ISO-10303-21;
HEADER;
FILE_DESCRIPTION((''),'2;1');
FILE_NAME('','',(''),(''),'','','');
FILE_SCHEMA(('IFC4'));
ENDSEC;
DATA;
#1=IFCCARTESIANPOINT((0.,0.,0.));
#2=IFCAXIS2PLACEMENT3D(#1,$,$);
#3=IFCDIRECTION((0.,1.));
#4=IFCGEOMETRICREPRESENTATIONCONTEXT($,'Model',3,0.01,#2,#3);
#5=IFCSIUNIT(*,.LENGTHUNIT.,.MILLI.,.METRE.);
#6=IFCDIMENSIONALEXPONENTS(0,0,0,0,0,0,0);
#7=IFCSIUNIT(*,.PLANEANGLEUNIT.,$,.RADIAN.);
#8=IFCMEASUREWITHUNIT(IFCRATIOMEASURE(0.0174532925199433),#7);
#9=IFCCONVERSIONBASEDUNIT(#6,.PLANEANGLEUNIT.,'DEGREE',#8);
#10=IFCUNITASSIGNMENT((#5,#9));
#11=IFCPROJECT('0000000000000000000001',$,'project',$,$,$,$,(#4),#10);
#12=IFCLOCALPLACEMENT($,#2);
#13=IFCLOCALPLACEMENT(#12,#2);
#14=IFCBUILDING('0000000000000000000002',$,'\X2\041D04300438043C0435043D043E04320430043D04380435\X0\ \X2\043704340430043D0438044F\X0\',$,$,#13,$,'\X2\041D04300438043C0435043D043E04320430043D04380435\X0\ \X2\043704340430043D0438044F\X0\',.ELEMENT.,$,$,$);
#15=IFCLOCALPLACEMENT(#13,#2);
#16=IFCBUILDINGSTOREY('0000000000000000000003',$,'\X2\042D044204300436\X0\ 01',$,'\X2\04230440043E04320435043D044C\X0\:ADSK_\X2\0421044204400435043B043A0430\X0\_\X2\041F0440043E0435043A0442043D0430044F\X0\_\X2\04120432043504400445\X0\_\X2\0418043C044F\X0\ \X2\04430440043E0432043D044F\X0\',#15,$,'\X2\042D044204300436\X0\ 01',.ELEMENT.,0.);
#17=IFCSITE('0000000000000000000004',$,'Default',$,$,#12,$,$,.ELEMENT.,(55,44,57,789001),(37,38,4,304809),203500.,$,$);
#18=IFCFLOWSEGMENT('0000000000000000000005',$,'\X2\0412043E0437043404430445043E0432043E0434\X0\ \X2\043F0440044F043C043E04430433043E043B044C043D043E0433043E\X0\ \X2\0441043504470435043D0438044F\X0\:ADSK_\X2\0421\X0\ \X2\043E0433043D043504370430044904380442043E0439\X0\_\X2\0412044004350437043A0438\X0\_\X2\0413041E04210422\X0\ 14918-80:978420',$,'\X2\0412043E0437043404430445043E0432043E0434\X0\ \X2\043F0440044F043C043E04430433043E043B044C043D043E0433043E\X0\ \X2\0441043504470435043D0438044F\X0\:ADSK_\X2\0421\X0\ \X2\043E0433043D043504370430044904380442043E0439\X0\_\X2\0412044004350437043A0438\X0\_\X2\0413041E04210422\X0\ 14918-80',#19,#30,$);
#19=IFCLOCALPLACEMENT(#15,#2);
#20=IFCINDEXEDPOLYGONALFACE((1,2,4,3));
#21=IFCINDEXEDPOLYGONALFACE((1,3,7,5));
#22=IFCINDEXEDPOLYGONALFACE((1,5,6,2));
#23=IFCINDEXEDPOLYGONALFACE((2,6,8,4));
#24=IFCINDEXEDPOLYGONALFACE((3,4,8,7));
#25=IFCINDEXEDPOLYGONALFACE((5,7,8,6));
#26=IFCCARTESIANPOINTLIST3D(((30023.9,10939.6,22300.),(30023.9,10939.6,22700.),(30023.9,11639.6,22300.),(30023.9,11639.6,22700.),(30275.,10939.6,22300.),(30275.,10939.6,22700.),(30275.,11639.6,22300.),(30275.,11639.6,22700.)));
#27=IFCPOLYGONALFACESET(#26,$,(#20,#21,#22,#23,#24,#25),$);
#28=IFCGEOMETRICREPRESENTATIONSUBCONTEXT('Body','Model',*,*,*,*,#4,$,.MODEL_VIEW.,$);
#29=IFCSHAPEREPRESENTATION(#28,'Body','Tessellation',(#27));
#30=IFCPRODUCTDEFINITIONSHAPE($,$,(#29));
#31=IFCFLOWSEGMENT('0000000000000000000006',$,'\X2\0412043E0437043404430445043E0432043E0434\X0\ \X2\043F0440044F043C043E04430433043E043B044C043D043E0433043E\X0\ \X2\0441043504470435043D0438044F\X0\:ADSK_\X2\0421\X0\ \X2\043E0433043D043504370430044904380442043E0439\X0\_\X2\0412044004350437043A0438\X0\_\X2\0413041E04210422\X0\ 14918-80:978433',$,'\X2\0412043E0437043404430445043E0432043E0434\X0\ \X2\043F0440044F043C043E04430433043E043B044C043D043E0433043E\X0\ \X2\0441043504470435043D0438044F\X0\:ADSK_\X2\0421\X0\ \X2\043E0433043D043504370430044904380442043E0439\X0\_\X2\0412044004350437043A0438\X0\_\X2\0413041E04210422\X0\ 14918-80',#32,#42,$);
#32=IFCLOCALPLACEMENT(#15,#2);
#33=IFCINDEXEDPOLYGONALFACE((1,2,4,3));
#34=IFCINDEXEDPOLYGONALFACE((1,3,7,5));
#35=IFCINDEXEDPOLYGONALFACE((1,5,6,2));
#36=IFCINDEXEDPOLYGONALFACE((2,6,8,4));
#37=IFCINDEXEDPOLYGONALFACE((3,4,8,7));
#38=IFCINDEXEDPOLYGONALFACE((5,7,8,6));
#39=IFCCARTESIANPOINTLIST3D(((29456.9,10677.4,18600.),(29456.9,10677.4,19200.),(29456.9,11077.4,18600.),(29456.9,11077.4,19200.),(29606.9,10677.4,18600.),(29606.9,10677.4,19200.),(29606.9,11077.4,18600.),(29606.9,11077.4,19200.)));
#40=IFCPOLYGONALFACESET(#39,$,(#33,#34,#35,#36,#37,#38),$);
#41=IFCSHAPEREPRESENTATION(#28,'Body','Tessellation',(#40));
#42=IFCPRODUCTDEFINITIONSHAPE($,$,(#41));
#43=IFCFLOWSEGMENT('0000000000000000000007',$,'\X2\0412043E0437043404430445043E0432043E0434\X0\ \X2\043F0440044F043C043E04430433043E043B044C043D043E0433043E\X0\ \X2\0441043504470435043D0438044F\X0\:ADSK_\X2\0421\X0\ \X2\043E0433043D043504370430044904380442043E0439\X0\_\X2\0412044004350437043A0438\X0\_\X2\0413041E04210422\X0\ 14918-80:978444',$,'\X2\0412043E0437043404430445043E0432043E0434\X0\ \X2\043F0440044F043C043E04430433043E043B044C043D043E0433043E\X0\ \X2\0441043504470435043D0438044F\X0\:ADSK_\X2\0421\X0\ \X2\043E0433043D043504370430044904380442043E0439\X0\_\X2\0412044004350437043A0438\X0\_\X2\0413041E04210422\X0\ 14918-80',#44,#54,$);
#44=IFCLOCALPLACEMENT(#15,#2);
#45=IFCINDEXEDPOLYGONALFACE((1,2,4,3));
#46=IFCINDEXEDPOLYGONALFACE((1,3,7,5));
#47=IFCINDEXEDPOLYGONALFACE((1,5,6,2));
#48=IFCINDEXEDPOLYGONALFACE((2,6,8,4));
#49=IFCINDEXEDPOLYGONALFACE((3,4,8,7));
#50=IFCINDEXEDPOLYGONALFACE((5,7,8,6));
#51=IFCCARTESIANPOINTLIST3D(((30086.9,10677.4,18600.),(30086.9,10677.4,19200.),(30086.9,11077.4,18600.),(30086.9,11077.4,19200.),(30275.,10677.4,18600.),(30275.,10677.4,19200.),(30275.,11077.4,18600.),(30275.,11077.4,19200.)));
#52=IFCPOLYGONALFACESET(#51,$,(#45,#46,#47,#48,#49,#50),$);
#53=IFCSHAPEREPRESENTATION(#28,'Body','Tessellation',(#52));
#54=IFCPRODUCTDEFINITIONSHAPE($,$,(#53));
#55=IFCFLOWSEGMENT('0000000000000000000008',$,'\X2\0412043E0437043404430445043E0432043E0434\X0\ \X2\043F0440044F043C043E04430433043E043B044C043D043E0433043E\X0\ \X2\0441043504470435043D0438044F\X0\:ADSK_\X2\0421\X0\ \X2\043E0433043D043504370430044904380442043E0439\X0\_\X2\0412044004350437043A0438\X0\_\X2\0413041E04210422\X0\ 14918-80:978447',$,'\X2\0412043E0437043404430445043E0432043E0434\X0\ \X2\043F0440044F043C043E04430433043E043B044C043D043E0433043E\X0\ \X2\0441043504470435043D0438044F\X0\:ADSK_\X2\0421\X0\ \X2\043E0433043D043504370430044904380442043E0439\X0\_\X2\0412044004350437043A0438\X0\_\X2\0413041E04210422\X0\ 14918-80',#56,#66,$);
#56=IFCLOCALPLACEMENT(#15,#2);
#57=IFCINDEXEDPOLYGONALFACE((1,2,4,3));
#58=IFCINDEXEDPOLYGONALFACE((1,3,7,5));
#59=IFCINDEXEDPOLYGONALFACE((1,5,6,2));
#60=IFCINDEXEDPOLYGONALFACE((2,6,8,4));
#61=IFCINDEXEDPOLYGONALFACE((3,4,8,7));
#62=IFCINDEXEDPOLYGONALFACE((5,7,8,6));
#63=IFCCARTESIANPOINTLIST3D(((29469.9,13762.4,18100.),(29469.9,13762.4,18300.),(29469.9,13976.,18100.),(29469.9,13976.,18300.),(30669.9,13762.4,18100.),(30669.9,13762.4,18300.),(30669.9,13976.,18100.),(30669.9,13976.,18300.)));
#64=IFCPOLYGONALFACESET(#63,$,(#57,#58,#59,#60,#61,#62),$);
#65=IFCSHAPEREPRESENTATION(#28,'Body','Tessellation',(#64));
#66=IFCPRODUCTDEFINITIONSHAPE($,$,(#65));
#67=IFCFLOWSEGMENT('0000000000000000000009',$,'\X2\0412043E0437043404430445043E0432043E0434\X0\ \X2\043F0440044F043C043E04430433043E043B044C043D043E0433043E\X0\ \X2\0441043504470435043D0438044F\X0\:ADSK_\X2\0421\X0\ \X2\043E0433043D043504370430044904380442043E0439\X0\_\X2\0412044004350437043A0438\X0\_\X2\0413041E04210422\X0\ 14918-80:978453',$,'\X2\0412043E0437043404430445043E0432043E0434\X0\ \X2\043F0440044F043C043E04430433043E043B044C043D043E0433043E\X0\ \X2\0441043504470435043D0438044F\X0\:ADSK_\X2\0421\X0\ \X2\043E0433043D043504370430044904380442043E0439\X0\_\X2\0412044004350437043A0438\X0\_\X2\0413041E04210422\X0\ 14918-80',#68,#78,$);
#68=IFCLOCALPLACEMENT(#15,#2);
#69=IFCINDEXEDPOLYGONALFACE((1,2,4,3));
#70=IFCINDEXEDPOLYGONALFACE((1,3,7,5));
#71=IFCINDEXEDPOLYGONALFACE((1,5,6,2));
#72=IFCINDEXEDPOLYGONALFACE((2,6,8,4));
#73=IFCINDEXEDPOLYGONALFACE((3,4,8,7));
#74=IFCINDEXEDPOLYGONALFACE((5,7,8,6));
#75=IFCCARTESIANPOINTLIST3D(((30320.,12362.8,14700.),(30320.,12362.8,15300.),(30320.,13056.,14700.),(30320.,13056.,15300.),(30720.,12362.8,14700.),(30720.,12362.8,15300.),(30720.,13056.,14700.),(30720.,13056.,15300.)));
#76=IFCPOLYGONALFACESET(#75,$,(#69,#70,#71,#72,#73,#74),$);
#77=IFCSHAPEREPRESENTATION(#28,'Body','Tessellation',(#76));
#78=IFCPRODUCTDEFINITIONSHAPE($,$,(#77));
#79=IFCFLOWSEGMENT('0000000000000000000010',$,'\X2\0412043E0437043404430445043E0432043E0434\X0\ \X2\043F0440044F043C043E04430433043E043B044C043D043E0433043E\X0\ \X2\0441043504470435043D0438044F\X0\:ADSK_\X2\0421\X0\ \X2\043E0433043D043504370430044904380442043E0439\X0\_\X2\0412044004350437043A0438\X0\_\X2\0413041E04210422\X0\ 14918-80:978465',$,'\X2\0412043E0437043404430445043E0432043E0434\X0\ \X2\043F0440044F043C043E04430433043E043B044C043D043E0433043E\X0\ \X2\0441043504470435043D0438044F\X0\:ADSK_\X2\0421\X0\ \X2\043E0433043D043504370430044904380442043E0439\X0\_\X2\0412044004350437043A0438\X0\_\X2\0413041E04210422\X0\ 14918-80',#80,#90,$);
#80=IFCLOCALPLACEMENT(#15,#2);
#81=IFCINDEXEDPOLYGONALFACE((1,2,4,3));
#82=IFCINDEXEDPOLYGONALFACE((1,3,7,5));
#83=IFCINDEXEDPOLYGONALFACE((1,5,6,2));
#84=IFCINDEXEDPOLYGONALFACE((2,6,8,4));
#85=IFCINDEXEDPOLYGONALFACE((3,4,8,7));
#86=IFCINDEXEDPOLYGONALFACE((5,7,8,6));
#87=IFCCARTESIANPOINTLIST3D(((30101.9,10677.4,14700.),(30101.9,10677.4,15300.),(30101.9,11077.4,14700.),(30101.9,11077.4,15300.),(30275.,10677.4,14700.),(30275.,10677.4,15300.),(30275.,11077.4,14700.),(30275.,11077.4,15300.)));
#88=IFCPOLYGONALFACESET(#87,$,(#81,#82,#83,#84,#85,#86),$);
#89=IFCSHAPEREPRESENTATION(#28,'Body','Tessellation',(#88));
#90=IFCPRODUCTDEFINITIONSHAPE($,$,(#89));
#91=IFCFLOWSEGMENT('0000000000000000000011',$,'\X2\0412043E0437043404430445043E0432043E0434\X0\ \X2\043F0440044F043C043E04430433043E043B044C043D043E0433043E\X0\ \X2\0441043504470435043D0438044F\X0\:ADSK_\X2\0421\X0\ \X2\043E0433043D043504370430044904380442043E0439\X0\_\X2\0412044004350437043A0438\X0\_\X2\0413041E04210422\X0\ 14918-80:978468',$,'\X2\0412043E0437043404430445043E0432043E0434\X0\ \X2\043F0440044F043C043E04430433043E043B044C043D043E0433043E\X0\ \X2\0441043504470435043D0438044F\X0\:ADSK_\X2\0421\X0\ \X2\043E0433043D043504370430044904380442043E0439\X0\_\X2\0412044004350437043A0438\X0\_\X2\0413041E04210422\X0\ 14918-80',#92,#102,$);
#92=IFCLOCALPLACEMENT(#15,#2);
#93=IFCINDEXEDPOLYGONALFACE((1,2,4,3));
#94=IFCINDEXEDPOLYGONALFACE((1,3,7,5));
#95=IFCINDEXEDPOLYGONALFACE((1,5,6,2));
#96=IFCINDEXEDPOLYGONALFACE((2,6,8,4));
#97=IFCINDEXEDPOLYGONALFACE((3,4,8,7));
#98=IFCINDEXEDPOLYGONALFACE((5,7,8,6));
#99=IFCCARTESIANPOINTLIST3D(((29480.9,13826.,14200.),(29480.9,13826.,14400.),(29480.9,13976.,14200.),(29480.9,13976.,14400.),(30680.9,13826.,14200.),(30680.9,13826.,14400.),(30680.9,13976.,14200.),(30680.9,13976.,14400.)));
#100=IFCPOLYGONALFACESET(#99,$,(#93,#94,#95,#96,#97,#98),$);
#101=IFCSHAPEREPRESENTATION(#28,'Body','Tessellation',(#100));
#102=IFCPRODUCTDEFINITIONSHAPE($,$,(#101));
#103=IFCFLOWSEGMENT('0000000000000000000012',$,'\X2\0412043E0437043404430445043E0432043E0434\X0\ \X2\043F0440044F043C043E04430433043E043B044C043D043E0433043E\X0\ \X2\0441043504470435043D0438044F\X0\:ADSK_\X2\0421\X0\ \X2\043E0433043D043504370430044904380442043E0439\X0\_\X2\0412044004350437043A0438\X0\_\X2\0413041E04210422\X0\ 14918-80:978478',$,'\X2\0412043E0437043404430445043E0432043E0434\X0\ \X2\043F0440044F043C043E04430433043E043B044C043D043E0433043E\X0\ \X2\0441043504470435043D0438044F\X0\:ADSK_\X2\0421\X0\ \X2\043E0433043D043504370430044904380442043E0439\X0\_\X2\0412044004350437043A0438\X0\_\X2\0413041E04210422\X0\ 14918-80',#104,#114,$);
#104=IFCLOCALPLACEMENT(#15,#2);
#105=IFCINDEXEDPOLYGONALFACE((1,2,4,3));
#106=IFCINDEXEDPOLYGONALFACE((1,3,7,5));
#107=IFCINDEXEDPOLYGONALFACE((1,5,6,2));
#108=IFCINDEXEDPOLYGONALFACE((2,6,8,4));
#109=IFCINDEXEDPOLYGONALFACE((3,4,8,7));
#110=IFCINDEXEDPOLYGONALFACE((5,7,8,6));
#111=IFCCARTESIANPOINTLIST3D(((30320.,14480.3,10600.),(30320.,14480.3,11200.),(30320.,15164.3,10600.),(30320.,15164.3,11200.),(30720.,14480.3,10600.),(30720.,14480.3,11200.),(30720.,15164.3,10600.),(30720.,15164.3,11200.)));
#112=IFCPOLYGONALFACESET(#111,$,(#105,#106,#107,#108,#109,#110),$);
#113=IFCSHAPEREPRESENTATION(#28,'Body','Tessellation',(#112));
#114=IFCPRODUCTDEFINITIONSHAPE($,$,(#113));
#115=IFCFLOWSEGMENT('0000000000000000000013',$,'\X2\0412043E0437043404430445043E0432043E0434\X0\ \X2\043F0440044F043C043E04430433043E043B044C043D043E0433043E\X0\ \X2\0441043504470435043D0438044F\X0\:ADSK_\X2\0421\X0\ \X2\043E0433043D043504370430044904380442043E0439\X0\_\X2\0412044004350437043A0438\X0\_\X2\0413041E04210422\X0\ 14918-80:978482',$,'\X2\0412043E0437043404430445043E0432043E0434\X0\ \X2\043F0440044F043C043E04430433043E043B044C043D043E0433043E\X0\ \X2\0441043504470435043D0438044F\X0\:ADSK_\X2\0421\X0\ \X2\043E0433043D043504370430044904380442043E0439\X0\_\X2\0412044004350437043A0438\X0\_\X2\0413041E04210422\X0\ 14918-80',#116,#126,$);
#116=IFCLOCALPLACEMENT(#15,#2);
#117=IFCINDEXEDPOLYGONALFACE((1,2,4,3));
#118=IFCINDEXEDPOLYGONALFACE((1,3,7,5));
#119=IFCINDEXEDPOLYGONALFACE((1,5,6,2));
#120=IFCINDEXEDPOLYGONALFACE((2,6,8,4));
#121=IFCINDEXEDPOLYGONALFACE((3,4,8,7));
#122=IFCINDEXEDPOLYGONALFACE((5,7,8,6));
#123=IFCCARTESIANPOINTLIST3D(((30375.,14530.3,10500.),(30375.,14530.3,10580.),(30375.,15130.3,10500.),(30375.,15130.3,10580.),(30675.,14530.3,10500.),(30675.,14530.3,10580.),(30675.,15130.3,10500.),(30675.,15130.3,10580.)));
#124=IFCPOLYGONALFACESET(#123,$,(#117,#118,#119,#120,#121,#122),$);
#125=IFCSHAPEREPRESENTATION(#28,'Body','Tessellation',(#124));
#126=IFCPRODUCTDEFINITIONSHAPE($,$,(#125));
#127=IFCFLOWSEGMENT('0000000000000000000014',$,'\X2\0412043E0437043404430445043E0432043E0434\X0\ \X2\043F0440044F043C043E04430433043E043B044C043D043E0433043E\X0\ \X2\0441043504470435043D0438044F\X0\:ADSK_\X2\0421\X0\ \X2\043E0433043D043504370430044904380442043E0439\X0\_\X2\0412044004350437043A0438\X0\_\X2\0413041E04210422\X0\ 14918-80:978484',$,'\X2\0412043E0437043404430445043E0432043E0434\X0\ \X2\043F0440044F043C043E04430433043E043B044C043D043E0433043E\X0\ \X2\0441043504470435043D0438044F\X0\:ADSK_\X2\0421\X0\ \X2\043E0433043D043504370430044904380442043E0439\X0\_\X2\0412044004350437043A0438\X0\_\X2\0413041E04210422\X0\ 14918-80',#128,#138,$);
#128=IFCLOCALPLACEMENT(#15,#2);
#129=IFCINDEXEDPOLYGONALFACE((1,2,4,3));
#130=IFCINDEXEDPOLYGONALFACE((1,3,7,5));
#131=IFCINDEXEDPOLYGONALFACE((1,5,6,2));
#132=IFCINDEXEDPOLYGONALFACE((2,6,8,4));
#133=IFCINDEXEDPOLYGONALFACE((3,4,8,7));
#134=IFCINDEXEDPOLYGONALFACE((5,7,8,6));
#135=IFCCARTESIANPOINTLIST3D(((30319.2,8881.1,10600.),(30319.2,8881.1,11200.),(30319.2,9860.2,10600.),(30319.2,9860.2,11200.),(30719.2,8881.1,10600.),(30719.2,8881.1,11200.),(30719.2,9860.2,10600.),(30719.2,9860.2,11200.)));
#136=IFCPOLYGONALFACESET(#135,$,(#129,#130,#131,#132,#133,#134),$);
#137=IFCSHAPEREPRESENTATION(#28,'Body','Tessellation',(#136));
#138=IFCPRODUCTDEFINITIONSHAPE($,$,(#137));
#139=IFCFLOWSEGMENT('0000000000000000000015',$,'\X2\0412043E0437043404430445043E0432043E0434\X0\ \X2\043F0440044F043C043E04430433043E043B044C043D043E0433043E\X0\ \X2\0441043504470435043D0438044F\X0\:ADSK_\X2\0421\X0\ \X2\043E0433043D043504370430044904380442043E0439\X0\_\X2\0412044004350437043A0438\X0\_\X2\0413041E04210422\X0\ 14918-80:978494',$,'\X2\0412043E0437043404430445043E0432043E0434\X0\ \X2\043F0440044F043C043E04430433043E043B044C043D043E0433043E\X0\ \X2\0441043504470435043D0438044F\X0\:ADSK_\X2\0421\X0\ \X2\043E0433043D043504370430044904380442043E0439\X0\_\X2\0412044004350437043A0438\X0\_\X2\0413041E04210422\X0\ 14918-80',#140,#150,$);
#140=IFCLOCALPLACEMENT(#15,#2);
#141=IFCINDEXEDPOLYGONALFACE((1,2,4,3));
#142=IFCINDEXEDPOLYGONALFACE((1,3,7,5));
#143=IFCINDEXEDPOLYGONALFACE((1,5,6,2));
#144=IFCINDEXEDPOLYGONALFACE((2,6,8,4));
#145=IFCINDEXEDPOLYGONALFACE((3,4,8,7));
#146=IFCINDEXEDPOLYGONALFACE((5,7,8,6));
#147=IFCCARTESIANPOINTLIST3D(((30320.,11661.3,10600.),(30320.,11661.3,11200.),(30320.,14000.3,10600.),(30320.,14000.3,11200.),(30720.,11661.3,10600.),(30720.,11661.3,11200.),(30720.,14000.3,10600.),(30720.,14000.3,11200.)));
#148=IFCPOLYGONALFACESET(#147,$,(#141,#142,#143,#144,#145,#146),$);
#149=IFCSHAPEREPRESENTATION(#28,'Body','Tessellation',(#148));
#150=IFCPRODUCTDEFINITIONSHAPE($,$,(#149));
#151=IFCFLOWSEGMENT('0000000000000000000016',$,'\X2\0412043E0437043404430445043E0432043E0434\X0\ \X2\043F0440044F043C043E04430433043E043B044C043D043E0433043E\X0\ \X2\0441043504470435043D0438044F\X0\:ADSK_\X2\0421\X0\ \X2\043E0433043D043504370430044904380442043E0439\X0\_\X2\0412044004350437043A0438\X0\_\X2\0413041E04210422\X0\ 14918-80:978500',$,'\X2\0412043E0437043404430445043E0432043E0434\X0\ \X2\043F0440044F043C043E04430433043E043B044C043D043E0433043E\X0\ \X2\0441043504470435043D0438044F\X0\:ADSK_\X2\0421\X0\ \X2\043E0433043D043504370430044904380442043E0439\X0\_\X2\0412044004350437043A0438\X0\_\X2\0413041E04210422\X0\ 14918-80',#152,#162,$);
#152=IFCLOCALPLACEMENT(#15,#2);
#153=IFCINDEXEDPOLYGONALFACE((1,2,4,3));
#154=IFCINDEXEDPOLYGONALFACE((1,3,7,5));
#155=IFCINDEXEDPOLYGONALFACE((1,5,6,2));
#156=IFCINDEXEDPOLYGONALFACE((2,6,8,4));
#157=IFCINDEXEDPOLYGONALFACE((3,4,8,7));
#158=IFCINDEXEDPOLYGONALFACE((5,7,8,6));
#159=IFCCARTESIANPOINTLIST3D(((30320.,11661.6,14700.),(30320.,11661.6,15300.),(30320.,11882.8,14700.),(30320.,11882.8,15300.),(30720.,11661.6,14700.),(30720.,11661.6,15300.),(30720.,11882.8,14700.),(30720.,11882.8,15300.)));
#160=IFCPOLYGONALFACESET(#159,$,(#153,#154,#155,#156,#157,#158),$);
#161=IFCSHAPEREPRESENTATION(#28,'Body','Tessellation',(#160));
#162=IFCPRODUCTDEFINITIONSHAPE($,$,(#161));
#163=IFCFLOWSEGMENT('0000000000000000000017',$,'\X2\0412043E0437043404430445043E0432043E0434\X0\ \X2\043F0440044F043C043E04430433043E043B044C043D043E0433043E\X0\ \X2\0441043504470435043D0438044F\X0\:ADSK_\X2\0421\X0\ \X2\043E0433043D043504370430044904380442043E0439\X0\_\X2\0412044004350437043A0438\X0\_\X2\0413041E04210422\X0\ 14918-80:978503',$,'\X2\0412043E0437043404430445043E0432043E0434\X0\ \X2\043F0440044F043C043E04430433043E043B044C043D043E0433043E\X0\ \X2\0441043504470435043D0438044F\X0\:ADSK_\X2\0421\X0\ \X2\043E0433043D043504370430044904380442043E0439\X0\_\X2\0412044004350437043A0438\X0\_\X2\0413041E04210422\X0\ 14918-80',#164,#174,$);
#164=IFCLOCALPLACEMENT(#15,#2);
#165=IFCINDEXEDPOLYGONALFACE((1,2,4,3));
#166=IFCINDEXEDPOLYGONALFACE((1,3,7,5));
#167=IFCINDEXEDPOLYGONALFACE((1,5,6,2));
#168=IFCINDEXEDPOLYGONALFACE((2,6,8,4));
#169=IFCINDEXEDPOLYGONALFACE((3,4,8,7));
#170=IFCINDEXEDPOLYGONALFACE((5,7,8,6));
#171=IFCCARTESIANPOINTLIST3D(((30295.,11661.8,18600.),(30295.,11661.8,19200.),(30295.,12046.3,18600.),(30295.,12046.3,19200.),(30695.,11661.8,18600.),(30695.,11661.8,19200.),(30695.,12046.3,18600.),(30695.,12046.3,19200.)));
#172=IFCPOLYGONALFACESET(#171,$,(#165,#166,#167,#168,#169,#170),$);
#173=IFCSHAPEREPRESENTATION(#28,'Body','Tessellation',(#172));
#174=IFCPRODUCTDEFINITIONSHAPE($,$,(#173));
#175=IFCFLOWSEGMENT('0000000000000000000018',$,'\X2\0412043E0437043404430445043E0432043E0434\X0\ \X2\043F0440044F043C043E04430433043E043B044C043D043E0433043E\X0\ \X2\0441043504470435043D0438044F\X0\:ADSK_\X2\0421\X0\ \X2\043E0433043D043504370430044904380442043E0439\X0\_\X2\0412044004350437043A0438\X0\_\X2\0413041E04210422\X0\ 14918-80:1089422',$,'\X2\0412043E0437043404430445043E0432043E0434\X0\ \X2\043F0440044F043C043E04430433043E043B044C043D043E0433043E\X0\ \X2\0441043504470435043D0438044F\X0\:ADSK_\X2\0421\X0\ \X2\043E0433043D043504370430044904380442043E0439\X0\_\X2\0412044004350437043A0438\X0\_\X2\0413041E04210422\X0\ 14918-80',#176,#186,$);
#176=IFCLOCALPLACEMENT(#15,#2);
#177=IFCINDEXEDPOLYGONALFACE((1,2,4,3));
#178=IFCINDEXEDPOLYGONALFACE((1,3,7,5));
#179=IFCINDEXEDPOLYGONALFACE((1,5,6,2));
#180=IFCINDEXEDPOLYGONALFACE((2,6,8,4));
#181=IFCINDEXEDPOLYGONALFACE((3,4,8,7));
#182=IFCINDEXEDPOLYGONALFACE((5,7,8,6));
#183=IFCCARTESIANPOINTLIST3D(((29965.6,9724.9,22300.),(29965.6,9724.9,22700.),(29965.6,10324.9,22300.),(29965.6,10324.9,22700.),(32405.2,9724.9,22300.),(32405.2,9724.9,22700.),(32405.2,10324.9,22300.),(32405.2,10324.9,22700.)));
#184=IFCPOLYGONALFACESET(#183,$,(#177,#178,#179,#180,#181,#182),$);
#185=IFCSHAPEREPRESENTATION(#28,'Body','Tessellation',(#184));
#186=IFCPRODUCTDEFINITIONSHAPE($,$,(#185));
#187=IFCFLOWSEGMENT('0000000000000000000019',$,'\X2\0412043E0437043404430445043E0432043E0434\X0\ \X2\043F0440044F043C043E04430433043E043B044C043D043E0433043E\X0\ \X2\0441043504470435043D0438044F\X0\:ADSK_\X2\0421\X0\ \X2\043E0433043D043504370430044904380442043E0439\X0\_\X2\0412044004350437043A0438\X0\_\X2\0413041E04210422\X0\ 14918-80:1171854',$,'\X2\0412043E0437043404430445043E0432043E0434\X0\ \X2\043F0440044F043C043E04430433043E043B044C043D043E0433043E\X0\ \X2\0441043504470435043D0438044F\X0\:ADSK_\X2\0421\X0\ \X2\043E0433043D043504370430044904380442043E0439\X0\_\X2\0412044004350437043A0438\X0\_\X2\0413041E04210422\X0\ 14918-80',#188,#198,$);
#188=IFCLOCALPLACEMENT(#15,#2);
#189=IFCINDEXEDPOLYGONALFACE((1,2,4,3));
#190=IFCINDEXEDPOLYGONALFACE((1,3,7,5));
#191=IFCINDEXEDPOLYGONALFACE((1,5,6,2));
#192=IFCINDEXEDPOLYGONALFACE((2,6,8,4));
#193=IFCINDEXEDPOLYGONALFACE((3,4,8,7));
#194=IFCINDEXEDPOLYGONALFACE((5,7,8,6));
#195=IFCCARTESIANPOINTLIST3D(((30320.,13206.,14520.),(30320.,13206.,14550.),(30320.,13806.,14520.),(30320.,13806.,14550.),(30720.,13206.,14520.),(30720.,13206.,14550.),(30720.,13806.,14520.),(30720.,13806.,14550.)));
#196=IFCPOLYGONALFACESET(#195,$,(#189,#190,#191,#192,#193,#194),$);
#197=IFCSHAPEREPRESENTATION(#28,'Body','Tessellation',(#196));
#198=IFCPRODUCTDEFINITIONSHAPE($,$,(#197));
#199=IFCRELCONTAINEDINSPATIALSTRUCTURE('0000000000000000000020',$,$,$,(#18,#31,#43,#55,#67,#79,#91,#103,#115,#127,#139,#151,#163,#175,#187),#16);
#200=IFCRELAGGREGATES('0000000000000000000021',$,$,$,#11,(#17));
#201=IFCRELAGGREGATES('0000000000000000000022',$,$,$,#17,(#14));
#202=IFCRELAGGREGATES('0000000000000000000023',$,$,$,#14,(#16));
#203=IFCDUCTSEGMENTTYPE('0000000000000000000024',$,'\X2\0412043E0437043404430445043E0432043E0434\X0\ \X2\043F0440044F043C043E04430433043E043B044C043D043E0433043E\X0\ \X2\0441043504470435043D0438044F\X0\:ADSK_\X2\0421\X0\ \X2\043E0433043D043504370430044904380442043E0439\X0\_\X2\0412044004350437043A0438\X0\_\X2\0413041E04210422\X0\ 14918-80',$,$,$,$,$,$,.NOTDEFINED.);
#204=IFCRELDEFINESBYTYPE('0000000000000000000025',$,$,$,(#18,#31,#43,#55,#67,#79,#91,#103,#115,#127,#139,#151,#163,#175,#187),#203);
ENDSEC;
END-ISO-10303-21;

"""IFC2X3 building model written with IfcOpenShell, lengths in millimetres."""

from ifc_helpers import new_model, entity, si_unit, converted_unit, direction, frame, origin, origin_2d_with_axis, place, context, subcontext, project, spatial, rectangle, extrude, type_object, element, save


model = new_model("IFC2X3")

# Units and contexts
model_context = context("Model", 3, precision=0.01, world=origin(), true_north=direction((0.0, 1.0)))
body_context = subcontext(model_context, "Body", "Model", "MODEL_VIEW")
ifc_project = project(units=[si_unit("LENGTHUNIT", "METRE", prefix="MILLI"), converted_unit("PLANEANGLEUNIT", "DEGREE", entity("IfcRatioMeasure", 0.0174532925199433), si_unit("PLANEANGLEUNIT", "RADIAN"), dimensions=[0, 0, 0, 0, 0, 0, 0])], contexts=[model_context])

# Site, building, storey
site_placement = place(None, origin())
site = spatial("IfcSite", under=ifc_project, at=site_placement, Name="Default", CompositionType="ELEMENT", RefLatitude=(55, 44, 57, 789001), RefLongitude=(37, 38, 4, 304809), RefElevation=203500.0)
building_placement = place(site_placement, origin())
building = spatial("IfcBuilding", under=site, at=building_placement, Name="Наименование здания", LongName="Наименование здания", CompositionType="ELEMENT")
storey_placement = place(building_placement, origin())
storey = spatial("IfcBuildingStorey", under=building, at=storey_placement, Name="Этаж 01", ObjectType="Уровень:ADSK_Стрелка_Проектная_Вверх_Имя уровня", LongName="Этаж 01", CompositionType="ELEMENT", Elevation=0.0)

# Flow segments
duct_segment_type = type_object("IfcDuctSegmentType", Name="Воздуховод прямоугольного сечения:ADSK_С огнезащитой_Врезки_ГОСТ 14918-80", PredefinedType="NOTDEFINED")
flow_segment_1_placement = place(storey_placement, frame((30023.9, 10939.6, 22300.0)))
element("IfcFlowSegment", 1, at=flow_segment_1_placement, inside=storey, type_object=duct_segment_type, Name="Воздуховод прямоугольного сечения:ADSK_С огнезащитой_Врезки_ГОСТ 14918-80:978420", ObjectType="Воздуховод прямоугольного сечения:ADSK_С огнезащитой_Врезки_ГОСТ 14918-80", context=body_context, shape_type="SweptSolid", body=[
    extrude(rectangle(XDim=251.1, YDim=700.0, at=origin_2d_with_axis()), frame((125.5, 350.0, 0.0)), (0.0, 0.0, 1.0), 400.0),
])
flow_segment_2_placement = place(storey_placement, frame((29456.9, 10677.4, 18600.0)))
element("IfcFlowSegment", 2, at=flow_segment_2_placement, inside=storey, type_object=duct_segment_type, Name="Воздуховод прямоугольного сечения:ADSK_С огнезащитой_Врезки_ГОСТ 14918-80:978433", ObjectType="Воздуховод прямоугольного сечения:ADSK_С огнезащитой_Врезки_ГОСТ 14918-80", context=body_context, shape_type="SweptSolid", body=[
    extrude(rectangle(XDim=150.0, YDim=400.0, at=origin_2d_with_axis()), frame((75.0, 200.0, 0.0), z_axis=(0.0, 0.0, 1.0), x_axis=(-1.0, 0.0, 0.0)), (0.0, 0.0, 1.0), 600.0),
])
flow_segment_3_placement = place(storey_placement, frame((30086.9, 10677.4, 18600.0)))
element("IfcFlowSegment", 3, at=flow_segment_3_placement, inside=storey, type_object=duct_segment_type, Name="Воздуховод прямоугольного сечения:ADSK_С огнезащитой_Врезки_ГОСТ 14918-80:978444", ObjectType="Воздуховод прямоугольного сечения:ADSK_С огнезащитой_Врезки_ГОСТ 14918-80", context=body_context, shape_type="SweptSolid", body=[
    extrude(rectangle(XDim=188.1, YDim=400.0, at=origin_2d_with_axis()), frame((94.0, 200.0, 0.0), z_axis=(0.0, 0.0, 1.0), x_axis=(-1.0, 0.0, 0.0)), (0.0, 0.0, 1.0), 600.0),
])
flow_segment_4_placement = place(storey_placement, frame((29469.9, 13762.4, 18100.0)))
element("IfcFlowSegment", 4, at=flow_segment_4_placement, inside=storey, type_object=duct_segment_type, Name="Воздуховод прямоугольного сечения:ADSK_С огнезащитой_Врезки_ГОСТ 14918-80:978447", ObjectType="Воздуховод прямоугольного сечения:ADSK_С огнезащитой_Врезки_ГОСТ 14918-80", context=body_context, shape_type="SweptSolid", body=[
    extrude(rectangle(XDim=213.6, YDim=1200.0, at=origin_2d_with_axis()), frame((600.0, 106.8, 0.0), z_axis=(0.0, 0.0, 1.0), x_axis=(0.0, -1.0, 0.0)), (0.0, 0.0, 1.0), 200.0),
])
flow_segment_5_placement = place(storey_placement, frame((30320.0, 12362.8, 14700.0)))
element("IfcFlowSegment", 5, at=flow_segment_5_placement, inside=storey, type_object=duct_segment_type, Name="Воздуховод прямоугольного сечения:ADSK_С огнезащитой_Врезки_ГОСТ 14918-80:978453", ObjectType="Воздуховод прямоугольного сечения:ADSK_С огнезащитой_Врезки_ГОСТ 14918-80", context=body_context, shape_type="SweptSolid", body=[
    extrude(rectangle(XDim=693.3, YDim=400.0, at=origin_2d_with_axis()), frame((200.0, 346.6, 0.0), z_axis=(0.0, 0.0, 1.0), x_axis=(0.0, 1.0, 0.0)), (0.0, 0.0, 1.0), 600.0),
])
flow_segment_6_placement = place(storey_placement, frame((30101.9, 10677.4, 14700.0)))
element("IfcFlowSegment", 6, at=flow_segment_6_placement, inside=storey, type_object=duct_segment_type, Name="Воздуховод прямоугольного сечения:ADSK_С огнезащитой_Врезки_ГОСТ 14918-80:978465", ObjectType="Воздуховод прямоугольного сечения:ADSK_С огнезащитой_Врезки_ГОСТ 14918-80", context=body_context, shape_type="SweptSolid", body=[
    extrude(rectangle(XDim=173.1, YDim=400.0, at=origin_2d_with_axis()), frame((86.5, 200.0, 0.0), z_axis=(0.0, 0.0, 1.0), x_axis=(-1.0, 0.0, 0.0)), (0.0, 0.0, 1.0), 600.0),
])
flow_segment_7_placement = place(storey_placement, frame((29480.9, 13826.0, 14200.0)))
element("IfcFlowSegment", 7, at=flow_segment_7_placement, inside=storey, type_object=duct_segment_type, Name="Воздуховод прямоугольного сечения:ADSK_С огнезащитой_Врезки_ГОСТ 14918-80:978468", ObjectType="Воздуховод прямоугольного сечения:ADSK_С огнезащитой_Врезки_ГОСТ 14918-80", context=body_context, shape_type="SweptSolid", body=[
    extrude(rectangle(XDim=150.0, YDim=1200.0, at=origin_2d_with_axis()), frame((600.0, 75.0, 0.0), z_axis=(0.0, 0.0, 1.0), x_axis=(0.0, -1.0, 0.0)), (0.0, 0.0, 1.0), 200.0),
])
flow_segment_8_placement = place(storey_placement, frame((30320.0, 14480.3, 10600.0)))
element("IfcFlowSegment", 8, at=flow_segment_8_placement, inside=storey, type_object=duct_segment_type, Name="Воздуховод прямоугольного сечения:ADSK_С огнезащитой_Врезки_ГОСТ 14918-80:978478", ObjectType="Воздуховод прямоугольного сечения:ADSK_С огнезащитой_Врезки_ГОСТ 14918-80", context=body_context, shape_type="SweptSolid", body=[
    extrude(rectangle(XDim=684.0, YDim=400.0, at=origin_2d_with_axis()), frame((200.0, 342.0, 0.0), z_axis=(0.0, 0.0, 1.0), x_axis=(0.0, 1.0, 0.0)), (0.0, 0.0, 1.0), 600.0),
])
flow_segment_9_placement = place(storey_placement, frame((30375.0, 14530.3, 10500.0)))
element("IfcFlowSegment", 9, at=flow_segment_9_placement, inside=storey, type_object=duct_segment_type, Name="Воздуховод прямоугольного сечения:ADSK_С огнезащитой_Врезки_ГОСТ 14918-80:978482", ObjectType="Воздуховод прямоугольного сечения:ADSK_С огнезащитой_Врезки_ГОСТ 14918-80", context=body_context, shape_type="SweptSolid", body=[
    extrude(rectangle(XDim=300.0, YDim=600.0, at=origin_2d_with_axis()), frame((150.0, 300.0, 0.0), z_axis=(0.0, 0.0, 1.0), x_axis=(-1.0, 0.0, 0.0)), (0.0, 0.0, 1.0), 80.0),
])
flow_segment_10_placement = place(storey_placement, frame((30319.2, 8881.1, 10600.0)))
element("IfcFlowSegment", 10, at=flow_segment_10_placement, inside=storey, type_object=duct_segment_type, Name="Воздуховод прямоугольного сечения:ADSK_С огнезащитой_Врезки_ГОСТ 14918-80:978484", ObjectType="Воздуховод прямоугольного сечения:ADSK_С огнезащитой_Врезки_ГОСТ 14918-80", context=body_context, shape_type="SweptSolid", body=[
    extrude(rectangle(XDim=979.2, YDim=400.0, at=origin_2d_with_axis()), frame((200.0, 489.6, 0.0), z_axis=(0.0, 0.0, 1.0), x_axis=(0.0, -1.0, 0.0)), (0.0, 0.0, 1.0), 600.0),
])
flow_segment_11_placement = place(storey_placement, frame((30320.0, 11661.3, 10600.0)))
element("IfcFlowSegment", 11, at=flow_segment_11_placement, inside=storey, type_object=duct_segment_type, Name="Воздуховод прямоугольного сечения:ADSK_С огнезащитой_Врезки_ГОСТ 14918-80:978494", ObjectType="Воздуховод прямоугольного сечения:ADSK_С огнезащитой_Врезки_ГОСТ 14918-80", context=body_context, shape_type="SweptSolid", body=[
    extrude(rectangle(XDim=2339.0, YDim=400.0, at=origin_2d_with_axis()), frame((200.0, 1169.5, 0.0), z_axis=(0.0, 0.0, 1.0), x_axis=(0.0, 1.0, 0.0)), (0.0, 0.0, 1.0), 600.0),
])
flow_segment_12_placement = place(storey_placement, frame((30320.0, 11661.6, 14700.0)))
element("IfcFlowSegment", 12, at=flow_segment_12_placement, inside=storey, type_object=duct_segment_type, Name="Воздуховод прямоугольного сечения:ADSK_С огнезащитой_Врезки_ГОСТ 14918-80:978500", ObjectType="Воздуховод прямоугольного сечения:ADSK_С огнезащитой_Врезки_ГОСТ 14918-80", context=body_context, shape_type="SweptSolid", body=[
    extrude(rectangle(XDim=221.2, YDim=400.0, at=origin_2d_with_axis()), frame((200.0, 110.6, 0.0), z_axis=(0.0, 0.0, 1.0), x_axis=(0.0, 1.0, 0.0)), (0.0, 0.0, 1.0), 600.0),
])
flow_segment_13_placement = place(storey_placement, frame((30295.0, 11661.8, 18600.0)))
element("IfcFlowSegment", 13, at=flow_segment_13_placement, inside=storey, type_object=duct_segment_type, Name="Воздуховод прямоугольного сечения:ADSK_С огнезащитой_Врезки_ГОСТ 14918-80:978503", ObjectType="Воздуховод прямоугольного сечения:ADSK_С огнезащитой_Врезки_ГОСТ 14918-80", context=body_context, shape_type="SweptSolid", body=[
    extrude(rectangle(XDim=384.5, YDim=400.0, at=origin_2d_with_axis()), frame((200.0, 192.2, 0.0), z_axis=(0.0, 0.0, 1.0), x_axis=(0.0, -1.0, 0.0)), (0.0, 0.0, 1.0), 600.0),
])
flow_segment_14_placement = place(storey_placement, frame((29965.6, 9724.9, 22300.0)))
element("IfcFlowSegment", 14, at=flow_segment_14_placement, inside=storey, type_object=duct_segment_type, Name="Воздуховод прямоугольного сечения:ADSK_С огнезащитой_Врезки_ГОСТ 14918-80:1089422", ObjectType="Воздуховод прямоугольного сечения:ADSK_С огнезащитой_Врезки_ГОСТ 14918-80", context=body_context, shape_type="SweptSolid", body=[
    extrude(rectangle(XDim=2439.6, YDim=600.0, at=origin_2d_with_axis()), frame((1219.8, 300.0, 0.0), z_axis=(0.0, 0.0, 1.0), x_axis=(-1.0, 0.0, 0.0)), (0.0, 0.0, 1.0), 400.0),
])
flow_segment_15_placement = place(storey_placement, frame((30320.0, 13206.0, 14520.0)))
element("IfcFlowSegment", 15, at=flow_segment_15_placement, inside=storey, type_object=duct_segment_type, Name="Воздуховод прямоугольного сечения:ADSK_С огнезащитой_Врезки_ГОСТ 14918-80:1171854", ObjectType="Воздуховод прямоугольного сечения:ADSK_С огнезащитой_Врезки_ГОСТ 14918-80", context=body_context, shape_type="SweptSolid", body=[
    extrude(rectangle(XDim=600.0, YDim=400.0, at=origin_2d_with_axis()), frame((200.0, 300.0, 0.0), z_axis=(0.0, 0.0, 1.0), x_axis=(0.0, -1.0, 0.0)), (0.0, 0.0, 1.0), 30.0),
])

save(model, "model.ifc")
